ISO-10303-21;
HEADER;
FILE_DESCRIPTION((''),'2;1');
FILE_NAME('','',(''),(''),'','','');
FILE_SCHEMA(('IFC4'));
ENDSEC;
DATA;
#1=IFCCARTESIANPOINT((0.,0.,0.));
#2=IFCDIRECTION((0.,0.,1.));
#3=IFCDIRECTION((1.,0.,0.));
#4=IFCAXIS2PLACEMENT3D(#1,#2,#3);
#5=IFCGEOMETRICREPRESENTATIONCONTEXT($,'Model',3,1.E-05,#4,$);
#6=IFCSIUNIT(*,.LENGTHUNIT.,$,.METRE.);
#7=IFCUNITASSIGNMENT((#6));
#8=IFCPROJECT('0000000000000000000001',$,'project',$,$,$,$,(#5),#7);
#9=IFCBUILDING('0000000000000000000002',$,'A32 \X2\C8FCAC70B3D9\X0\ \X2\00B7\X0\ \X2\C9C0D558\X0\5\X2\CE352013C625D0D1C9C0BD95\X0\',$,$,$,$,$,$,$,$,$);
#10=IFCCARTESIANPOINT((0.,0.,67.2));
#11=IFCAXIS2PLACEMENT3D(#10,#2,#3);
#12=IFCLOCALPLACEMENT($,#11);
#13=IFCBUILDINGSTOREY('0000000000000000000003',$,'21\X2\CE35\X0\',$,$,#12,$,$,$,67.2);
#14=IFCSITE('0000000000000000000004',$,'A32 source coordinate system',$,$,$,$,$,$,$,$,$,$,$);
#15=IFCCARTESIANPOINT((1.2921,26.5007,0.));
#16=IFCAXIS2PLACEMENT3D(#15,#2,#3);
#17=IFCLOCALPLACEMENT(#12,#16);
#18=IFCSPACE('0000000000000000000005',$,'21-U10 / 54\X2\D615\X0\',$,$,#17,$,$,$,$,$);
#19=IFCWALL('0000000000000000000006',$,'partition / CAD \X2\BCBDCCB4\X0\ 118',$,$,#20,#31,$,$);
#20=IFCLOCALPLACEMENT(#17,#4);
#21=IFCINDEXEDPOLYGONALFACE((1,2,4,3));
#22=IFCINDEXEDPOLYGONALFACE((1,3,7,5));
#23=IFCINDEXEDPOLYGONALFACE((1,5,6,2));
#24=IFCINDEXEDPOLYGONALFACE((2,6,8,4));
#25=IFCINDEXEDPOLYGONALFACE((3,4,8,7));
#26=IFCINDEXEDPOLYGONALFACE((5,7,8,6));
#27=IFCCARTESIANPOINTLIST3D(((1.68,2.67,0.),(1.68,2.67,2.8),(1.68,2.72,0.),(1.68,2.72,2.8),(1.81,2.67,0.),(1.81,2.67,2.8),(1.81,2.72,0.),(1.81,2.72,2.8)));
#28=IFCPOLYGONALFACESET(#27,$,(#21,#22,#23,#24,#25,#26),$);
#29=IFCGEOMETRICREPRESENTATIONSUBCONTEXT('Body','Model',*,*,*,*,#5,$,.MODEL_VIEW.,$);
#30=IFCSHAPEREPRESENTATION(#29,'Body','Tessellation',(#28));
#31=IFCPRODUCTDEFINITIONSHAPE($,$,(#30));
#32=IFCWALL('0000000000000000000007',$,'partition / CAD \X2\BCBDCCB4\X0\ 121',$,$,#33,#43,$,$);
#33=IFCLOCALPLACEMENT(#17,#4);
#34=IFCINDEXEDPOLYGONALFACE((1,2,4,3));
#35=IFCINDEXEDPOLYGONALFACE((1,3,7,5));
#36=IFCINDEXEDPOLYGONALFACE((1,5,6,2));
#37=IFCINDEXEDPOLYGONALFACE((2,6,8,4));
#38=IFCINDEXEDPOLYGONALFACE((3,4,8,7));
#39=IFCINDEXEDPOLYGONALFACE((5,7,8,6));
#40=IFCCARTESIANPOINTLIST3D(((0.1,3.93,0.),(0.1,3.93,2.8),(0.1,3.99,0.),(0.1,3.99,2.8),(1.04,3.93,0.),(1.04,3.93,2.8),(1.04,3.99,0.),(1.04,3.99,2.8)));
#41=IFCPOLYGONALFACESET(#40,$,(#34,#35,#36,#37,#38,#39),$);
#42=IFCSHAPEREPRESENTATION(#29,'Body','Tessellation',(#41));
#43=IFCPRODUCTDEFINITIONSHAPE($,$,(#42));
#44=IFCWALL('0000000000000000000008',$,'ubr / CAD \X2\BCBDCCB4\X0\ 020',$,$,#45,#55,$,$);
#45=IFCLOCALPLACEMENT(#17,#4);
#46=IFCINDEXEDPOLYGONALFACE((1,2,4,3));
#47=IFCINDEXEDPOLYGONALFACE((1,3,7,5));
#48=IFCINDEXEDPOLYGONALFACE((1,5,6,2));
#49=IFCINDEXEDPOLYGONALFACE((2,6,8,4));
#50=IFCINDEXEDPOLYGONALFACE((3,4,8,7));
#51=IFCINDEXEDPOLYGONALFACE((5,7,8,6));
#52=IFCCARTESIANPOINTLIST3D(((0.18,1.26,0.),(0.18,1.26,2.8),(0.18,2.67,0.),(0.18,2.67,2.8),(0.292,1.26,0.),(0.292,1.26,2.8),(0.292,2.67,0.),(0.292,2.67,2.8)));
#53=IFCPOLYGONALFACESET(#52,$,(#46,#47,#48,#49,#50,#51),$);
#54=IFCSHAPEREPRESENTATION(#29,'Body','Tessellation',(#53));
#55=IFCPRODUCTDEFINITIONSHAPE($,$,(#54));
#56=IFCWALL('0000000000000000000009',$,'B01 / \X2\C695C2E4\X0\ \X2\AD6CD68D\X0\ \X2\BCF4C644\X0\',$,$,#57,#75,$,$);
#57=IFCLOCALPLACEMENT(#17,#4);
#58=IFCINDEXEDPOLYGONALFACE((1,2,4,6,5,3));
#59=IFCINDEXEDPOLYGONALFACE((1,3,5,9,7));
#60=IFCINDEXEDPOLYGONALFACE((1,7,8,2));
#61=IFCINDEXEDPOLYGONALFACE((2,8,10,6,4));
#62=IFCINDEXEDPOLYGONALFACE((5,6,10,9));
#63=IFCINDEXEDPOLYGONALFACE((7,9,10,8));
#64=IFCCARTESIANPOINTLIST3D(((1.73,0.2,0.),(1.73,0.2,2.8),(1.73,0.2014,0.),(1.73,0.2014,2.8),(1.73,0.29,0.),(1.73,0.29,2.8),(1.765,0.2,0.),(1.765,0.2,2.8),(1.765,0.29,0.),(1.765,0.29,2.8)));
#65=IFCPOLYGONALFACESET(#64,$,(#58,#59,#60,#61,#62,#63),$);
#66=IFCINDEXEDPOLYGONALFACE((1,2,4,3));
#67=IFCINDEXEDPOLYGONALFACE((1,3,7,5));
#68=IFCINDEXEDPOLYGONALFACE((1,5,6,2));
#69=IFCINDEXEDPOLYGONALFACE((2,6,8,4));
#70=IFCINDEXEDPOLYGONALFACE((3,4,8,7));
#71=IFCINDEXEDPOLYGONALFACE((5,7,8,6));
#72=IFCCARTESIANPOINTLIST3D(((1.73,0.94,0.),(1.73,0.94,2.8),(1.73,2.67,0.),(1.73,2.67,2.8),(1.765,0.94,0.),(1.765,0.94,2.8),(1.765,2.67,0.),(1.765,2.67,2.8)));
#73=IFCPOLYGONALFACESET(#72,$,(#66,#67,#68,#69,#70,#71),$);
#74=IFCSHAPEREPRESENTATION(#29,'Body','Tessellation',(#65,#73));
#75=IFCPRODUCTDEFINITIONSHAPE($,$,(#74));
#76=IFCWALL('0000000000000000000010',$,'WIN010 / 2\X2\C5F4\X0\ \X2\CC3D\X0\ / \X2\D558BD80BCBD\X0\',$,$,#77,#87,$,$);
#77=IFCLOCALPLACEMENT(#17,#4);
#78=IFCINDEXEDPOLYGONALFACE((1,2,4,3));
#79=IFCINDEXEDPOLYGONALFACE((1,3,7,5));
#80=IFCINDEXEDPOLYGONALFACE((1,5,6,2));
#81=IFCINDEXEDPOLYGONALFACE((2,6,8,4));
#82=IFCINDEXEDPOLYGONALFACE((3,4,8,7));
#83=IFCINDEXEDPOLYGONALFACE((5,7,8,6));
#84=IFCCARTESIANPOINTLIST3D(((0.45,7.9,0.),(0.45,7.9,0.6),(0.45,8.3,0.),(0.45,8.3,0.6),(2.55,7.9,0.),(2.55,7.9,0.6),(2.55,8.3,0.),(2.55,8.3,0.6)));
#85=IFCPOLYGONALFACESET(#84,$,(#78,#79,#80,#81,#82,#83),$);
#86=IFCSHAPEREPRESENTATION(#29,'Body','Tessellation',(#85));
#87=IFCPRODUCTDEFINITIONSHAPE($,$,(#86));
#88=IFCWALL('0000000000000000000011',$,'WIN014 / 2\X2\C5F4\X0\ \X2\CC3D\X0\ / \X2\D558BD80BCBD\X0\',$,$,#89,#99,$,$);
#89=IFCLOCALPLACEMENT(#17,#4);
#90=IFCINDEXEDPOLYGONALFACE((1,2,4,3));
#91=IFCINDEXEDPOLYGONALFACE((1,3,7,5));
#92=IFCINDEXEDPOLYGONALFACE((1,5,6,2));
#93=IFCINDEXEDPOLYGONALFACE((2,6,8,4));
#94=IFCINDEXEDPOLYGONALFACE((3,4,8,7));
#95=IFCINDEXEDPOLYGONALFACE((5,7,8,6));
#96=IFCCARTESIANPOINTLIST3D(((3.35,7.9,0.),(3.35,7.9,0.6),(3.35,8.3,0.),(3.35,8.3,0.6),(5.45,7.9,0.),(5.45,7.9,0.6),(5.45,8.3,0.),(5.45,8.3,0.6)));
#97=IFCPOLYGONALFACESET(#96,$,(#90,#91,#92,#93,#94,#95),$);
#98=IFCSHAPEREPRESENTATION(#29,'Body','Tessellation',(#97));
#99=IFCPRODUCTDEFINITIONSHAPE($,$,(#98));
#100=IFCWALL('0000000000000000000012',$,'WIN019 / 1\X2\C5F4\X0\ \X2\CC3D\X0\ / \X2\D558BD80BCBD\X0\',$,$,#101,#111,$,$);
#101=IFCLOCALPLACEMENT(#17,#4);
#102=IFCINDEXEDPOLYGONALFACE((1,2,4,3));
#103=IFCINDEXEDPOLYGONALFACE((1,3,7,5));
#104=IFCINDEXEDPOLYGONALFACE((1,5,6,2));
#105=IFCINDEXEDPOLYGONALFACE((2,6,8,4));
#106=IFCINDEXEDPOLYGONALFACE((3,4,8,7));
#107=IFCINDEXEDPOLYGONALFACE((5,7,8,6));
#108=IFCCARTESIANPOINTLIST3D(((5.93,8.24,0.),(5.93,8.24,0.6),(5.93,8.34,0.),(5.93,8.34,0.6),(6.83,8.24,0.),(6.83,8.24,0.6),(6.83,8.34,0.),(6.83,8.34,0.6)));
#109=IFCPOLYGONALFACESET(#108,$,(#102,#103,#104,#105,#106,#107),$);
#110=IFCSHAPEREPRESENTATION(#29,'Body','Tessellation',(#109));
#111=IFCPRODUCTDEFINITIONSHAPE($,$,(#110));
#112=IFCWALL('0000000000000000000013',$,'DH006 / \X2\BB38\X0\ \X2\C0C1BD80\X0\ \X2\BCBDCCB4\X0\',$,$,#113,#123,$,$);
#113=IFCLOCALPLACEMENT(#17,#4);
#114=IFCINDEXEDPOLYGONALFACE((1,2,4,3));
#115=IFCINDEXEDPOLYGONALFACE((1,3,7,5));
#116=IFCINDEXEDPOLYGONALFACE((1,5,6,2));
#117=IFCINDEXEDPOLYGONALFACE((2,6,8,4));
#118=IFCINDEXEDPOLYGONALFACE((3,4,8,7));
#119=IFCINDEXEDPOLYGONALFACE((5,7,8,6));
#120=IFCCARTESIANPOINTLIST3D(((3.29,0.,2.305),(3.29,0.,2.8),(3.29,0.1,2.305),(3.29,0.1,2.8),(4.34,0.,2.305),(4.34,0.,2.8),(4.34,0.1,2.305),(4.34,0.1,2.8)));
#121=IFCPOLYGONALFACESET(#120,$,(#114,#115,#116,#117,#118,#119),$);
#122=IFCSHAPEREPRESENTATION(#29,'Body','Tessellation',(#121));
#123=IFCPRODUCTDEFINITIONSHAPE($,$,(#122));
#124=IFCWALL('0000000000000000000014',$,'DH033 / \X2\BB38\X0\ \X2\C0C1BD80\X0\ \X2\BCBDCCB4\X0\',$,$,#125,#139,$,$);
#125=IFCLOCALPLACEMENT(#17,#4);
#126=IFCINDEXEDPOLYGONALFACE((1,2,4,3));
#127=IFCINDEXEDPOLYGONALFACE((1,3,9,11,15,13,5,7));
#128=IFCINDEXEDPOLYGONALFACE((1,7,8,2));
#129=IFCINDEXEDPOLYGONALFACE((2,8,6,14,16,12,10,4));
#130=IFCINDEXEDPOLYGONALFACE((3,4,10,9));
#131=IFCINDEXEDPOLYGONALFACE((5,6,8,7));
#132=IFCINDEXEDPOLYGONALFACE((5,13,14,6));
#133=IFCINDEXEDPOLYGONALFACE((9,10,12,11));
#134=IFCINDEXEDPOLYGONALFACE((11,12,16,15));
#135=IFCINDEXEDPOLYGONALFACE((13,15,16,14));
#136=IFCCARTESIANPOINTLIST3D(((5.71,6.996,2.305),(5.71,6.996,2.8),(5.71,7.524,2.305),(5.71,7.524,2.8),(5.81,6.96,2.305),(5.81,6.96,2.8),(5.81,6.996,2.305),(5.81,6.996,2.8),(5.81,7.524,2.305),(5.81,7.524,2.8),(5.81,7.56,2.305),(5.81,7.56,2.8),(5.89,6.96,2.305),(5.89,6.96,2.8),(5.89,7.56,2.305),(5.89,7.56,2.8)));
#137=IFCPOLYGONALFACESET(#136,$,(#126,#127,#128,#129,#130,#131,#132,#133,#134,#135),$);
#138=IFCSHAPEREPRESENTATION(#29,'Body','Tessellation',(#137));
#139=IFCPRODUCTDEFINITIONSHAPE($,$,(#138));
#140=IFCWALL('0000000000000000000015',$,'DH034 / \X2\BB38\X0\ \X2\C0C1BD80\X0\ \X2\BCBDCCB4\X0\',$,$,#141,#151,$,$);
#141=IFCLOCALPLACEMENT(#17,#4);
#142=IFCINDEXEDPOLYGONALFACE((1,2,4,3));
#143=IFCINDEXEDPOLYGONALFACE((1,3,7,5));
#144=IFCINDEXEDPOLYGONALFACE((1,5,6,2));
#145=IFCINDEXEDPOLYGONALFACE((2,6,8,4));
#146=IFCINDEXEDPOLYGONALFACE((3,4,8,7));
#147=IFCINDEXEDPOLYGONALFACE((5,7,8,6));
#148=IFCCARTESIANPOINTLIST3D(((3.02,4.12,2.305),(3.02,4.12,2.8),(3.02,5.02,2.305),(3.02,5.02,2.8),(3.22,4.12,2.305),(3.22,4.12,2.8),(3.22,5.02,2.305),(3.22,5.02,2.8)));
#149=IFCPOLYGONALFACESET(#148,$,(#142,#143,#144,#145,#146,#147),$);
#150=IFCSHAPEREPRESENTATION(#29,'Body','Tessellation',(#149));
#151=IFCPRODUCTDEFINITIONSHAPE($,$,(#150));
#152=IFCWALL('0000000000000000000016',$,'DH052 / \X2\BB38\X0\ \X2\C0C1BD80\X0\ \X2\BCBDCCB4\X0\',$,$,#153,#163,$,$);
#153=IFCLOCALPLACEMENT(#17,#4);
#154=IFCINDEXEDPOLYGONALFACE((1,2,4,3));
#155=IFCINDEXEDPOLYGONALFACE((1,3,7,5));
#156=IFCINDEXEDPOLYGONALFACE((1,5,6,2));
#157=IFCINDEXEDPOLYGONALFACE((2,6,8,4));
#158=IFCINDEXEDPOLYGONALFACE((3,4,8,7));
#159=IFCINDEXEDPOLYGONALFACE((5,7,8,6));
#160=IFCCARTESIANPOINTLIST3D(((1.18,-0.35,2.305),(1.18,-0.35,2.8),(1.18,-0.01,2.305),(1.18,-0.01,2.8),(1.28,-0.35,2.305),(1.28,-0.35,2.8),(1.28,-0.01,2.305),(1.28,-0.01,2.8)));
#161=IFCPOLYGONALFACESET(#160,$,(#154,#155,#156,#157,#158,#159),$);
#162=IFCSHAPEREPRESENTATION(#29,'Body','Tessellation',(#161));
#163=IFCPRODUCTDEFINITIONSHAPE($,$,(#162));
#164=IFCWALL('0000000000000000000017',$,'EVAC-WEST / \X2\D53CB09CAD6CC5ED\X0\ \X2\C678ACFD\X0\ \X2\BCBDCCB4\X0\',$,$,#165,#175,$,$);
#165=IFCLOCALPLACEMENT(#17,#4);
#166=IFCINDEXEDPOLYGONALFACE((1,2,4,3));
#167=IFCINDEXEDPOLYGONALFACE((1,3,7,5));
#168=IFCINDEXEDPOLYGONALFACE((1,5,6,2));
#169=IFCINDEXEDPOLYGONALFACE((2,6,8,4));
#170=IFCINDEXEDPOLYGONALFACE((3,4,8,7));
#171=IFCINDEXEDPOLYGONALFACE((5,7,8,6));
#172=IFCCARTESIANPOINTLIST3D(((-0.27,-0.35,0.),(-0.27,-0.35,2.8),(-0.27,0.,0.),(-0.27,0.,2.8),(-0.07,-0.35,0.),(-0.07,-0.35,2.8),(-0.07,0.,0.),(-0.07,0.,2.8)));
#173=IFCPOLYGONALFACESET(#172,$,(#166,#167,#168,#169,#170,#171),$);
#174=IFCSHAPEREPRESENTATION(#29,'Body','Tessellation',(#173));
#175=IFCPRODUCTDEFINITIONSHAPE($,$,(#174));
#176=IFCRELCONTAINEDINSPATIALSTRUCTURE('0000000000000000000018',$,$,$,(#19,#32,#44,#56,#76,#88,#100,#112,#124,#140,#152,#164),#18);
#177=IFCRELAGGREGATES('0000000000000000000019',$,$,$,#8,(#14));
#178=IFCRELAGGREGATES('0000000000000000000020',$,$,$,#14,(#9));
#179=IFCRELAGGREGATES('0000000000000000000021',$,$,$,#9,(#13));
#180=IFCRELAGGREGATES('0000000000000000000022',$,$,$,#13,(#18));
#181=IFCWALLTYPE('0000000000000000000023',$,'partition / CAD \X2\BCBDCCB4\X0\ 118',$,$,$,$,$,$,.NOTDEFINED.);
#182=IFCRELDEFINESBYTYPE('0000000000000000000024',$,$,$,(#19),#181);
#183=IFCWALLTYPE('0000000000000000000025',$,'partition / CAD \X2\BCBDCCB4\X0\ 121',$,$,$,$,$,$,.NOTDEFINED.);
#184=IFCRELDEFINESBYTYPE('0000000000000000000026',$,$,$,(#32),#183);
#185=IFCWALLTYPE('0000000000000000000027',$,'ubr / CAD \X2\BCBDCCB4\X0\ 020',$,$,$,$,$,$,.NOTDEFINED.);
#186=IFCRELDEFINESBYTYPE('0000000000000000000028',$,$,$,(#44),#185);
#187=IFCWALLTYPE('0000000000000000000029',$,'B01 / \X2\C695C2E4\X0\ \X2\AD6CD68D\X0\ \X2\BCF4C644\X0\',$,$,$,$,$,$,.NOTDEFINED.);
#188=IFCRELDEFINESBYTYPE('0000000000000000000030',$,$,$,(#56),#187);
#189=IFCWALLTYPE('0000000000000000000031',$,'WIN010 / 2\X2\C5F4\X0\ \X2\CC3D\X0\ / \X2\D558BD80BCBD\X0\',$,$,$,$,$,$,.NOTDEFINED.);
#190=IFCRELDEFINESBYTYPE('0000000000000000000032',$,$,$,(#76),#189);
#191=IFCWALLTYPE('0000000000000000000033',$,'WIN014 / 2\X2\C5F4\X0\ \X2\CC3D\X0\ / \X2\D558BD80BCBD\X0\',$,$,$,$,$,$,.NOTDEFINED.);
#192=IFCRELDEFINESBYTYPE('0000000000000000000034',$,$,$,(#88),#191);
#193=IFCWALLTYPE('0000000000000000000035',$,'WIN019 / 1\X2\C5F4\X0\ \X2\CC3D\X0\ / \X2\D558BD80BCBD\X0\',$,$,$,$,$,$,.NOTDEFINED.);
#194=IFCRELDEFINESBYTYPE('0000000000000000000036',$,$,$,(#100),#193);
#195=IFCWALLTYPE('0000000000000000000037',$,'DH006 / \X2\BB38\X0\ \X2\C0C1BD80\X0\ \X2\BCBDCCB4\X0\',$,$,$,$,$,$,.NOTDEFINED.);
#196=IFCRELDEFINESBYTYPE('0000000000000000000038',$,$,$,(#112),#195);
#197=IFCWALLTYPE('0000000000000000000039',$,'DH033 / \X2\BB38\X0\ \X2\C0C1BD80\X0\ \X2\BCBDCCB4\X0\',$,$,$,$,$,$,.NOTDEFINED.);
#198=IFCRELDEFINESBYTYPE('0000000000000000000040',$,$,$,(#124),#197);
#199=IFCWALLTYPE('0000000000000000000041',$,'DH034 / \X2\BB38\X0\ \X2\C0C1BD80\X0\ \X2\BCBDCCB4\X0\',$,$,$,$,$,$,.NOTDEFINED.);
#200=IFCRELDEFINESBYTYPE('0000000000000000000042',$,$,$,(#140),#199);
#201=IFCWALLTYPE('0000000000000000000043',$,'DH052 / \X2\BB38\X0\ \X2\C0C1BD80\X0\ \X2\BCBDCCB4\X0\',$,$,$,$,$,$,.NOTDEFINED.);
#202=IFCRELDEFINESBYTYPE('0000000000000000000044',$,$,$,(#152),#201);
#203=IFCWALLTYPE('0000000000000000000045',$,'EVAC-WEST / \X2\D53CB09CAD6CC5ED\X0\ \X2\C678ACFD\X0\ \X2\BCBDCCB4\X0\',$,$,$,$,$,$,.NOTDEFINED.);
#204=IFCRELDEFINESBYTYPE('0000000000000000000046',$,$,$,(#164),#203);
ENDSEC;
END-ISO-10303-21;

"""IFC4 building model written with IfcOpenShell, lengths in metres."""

from ifc_helpers import new_model, si_unit, frame, origin, origin_with_axes, place, context, subcontext, project, spatial, polyline, outline, extrude, source, transform, mapped, type_object, type_shapes, element, save


model = new_model("IFC4")

# Units and contexts
model_context = context("Model", 3, precision=1e-05, world=origin_with_axes())
body_context = subcontext(model_context, "Body", "Model", "MODEL_VIEW")
ifc_project = project(units=[si_unit("LENGTHUNIT", "METRE")], contexts=[model_context])

# Site, building, storey, space
site = spatial("IfcSite", under=ifc_project, Name="A32 source coordinate system")
building = spatial("IfcBuilding", under=site, Name="A32 주거동 · 지하5층–옥탑지붕")
storey_placement = place(None, frame((0.0, 0.0, 67.2), z_axis=(0.0, 0.0, 1.0), x_axis=(1.0, 0.0, 0.0)))
storey = spatial("IfcBuildingStorey", under=building, at=storey_placement, Name="21층", Elevation=67.2)
space_placement = place(storey_placement, frame((1.2921, 26.5007, 0.0), z_axis=(0.0, 0.0, 1.0), x_axis=(1.0, 0.0, 0.0)))
space = spatial("IfcSpace", under=storey, at=space_placement, Name="21-U10 / 54형")

# Walls
wall_type_1 = type_object("IfcWallType", Name="partition / CAD 벽체 118", PredefinedType="NOTDEFINED")
shared_shape_1 = source(origin(), body_context, "Body", "SweptSolid", [
    extrude(outline(polyline([(1.81, 2.67), (1.68, 2.67), (1.68, 2.72), (1.81, 2.72), (1.81, 2.67)])), origin(), (0.0, 0.0, 1.0), 2.8),
])
type_shapes(wall_type_1, [shared_shape_1])
wall_1_placement = place(space_placement, origin_with_axes())
element("IfcWall", 1, at=wall_1_placement, inside=space, type_object=wall_type_1, Name="partition / CAD 벽체 118", context=body_context, shape_type="MappedRepresentation", body=[
    mapped(shared_shape_1, transform((0.0, 0.0, 0.0), scale=1.0)),
])
wall_type_2 = type_object("IfcWallType", Name="partition / CAD 벽체 121", PredefinedType="NOTDEFINED")
shared_shape_2 = source(origin(), body_context, "Body", "SweptSolid", [
    extrude(outline(polyline([(0.1, 3.99), (1.04, 3.99), (1.04, 3.93), (0.1, 3.93), (0.1, 3.99)])), origin(), (0.0, 0.0, 1.0), 2.8),
])
type_shapes(wall_type_2, [shared_shape_2])
wall_2_placement = place(space_placement, origin_with_axes())
element("IfcWall", 2, at=wall_2_placement, inside=space, type_object=wall_type_2, Name="partition / CAD 벽체 121", context=body_context, shape_type="MappedRepresentation", body=[
    mapped(shared_shape_2, transform((0.0, 0.0, 0.0), scale=1.0)),
])
wall_type_3 = type_object("IfcWallType", Name="ubr / CAD 벽체 020", PredefinedType="NOTDEFINED")
shared_shape_3 = source(origin(), body_context, "Body", "SweptSolid", [
    extrude(outline(polyline([(0.18, 1.26), (0.18, 2.67), (0.292, 2.67), (0.292, 1.26), (0.18, 1.26)])), origin(), (0.0, 0.0, 1.0), 2.8),
])
type_shapes(wall_type_3, [shared_shape_3])
wall_3_placement = place(space_placement, origin_with_axes())
element("IfcWall", 3, at=wall_3_placement, inside=space, type_object=wall_type_3, Name="ubr / CAD 벽체 020", context=body_context, shape_type="MappedRepresentation", body=[
    mapped(shared_shape_3, transform((0.0, 0.0, 0.0), scale=1.0)),
])
wall_type_4 = type_object("IfcWallType", Name="B01 / 욕실 구획 보완", PredefinedType="NOTDEFINED")
shared_shape_4 = source(origin(), body_context, "Body", "SweptSolid", [
    extrude(outline(polyline([(1.765, 0.2), (1.73, 0.2), (1.73, 0.2014), (1.73, 0.29), (1.765, 0.29), (1.765, 0.2)])), origin(), (0.0, 0.0, 1.0), 2.8),
    extrude(outline(polyline([(1.765, 2.67), (1.765, 0.94), (1.73, 0.94), (1.73, 2.67), (1.765, 2.67)])), origin(), (0.0, 0.0, 1.0), 2.8),
])
type_shapes(wall_type_4, [shared_shape_4])
wall_4_placement = place(space_placement, origin_with_axes())
element("IfcWall", 4, at=wall_4_placement, inside=space, type_object=wall_type_4, Name="B01 / 욕실 구획 보완", context=body_context, shape_type="MappedRepresentation", body=[
    mapped(shared_shape_4, transform((0.0, 0.0, 0.0), scale=1.0)),
])
wall_type_5 = type_object("IfcWallType", Name="WIN010 / 2열 창 / 하부벽", PredefinedType="NOTDEFINED")
shared_shape_5 = source(origin(), body_context, "Body", "SweptSolid", [
    extrude(outline(polyline([(2.55, 8.3), (2.55, 7.9), (0.45, 7.9), (0.45, 8.3), (2.55, 8.3)])), origin(), (0.0, 0.0, 1.0), 0.6),
])
type_shapes(wall_type_5, [shared_shape_5])
wall_5_placement = place(space_placement, origin_with_axes())
element("IfcWall", 5, at=wall_5_placement, inside=space, type_object=wall_type_5, Name="WIN010 / 2열 창 / 하부벽", context=body_context, shape_type="MappedRepresentation", body=[
    mapped(shared_shape_5, transform((0.0, 0.0, 0.0), scale=1.0)),
])
wall_type_6 = type_object("IfcWallType", Name="WIN014 / 2열 창 / 하부벽", PredefinedType="NOTDEFINED")
shared_shape_6 = source(origin(), body_context, "Body", "SweptSolid", [
    extrude(outline(polyline([(5.45, 8.3), (5.45, 7.9), (3.35, 7.9), (3.35, 8.3), (5.45, 8.3)])), origin(), (0.0, 0.0, 1.0), 0.6),
])
type_shapes(wall_type_6, [shared_shape_6])
wall_6_placement = place(space_placement, origin_with_axes())
element("IfcWall", 6, at=wall_6_placement, inside=space, type_object=wall_type_6, Name="WIN014 / 2열 창 / 하부벽", context=body_context, shape_type="MappedRepresentation", body=[
    mapped(shared_shape_6, transform((0.0, 0.0, 0.0), scale=1.0)),
])
wall_type_7 = type_object("IfcWallType", Name="WIN019 / 1열 창 / 하부벽", PredefinedType="NOTDEFINED")
shared_shape_7 = source(origin(), body_context, "Body", "SweptSolid", [
    extrude(outline(polyline([(6.83, 8.34), (6.83, 8.24), (5.93, 8.24), (5.93, 8.34), (6.83, 8.34)])), origin(), (0.0, 0.0, 1.0), 0.6),
])
type_shapes(wall_type_7, [shared_shape_7])
wall_7_placement = place(space_placement, origin_with_axes())
element("IfcWall", 7, at=wall_7_placement, inside=space, type_object=wall_type_7, Name="WIN019 / 1열 창 / 하부벽", context=body_context, shape_type="MappedRepresentation", body=[
    mapped(shared_shape_7, transform((0.0, 0.0, 0.0), scale=1.0)),
])
wall_type_8 = type_object("IfcWallType", Name="DH006 / 문 상부 벽체", PredefinedType="NOTDEFINED")
shared_shape_8 = source(origin(), body_context, "Body", "SweptSolid", [
    extrude(outline(polyline([(4.34, 0.0), (3.29, 0.0), (3.29, 0.1), (4.34, 0.1), (4.34, 0.0)])), frame((0.0, 0.0, 2.305)), (0.0, 0.0, 1.0), 0.495),
])
type_shapes(wall_type_8, [shared_shape_8])
wall_8_placement = place(space_placement, origin_with_axes())
element("IfcWall", 8, at=wall_8_placement, inside=space, type_object=wall_type_8, Name="DH006 / 문 상부 벽체", context=body_context, shape_type="MappedRepresentation", body=[
    mapped(shared_shape_8, transform((0.0, 0.0, 0.0), scale=1.0)),
])
wall_type_9 = type_object("IfcWallType", Name="DH033 / 문 상부 벽체", PredefinedType="NOTDEFINED")
shared_shape_9 = source(origin(), body_context, "Body", "SweptSolid", [
    extrude(outline(polyline([(5.81, 6.996), (5.71, 6.996), (5.71, 7.524), (5.81, 7.524), (5.81, 7.56), (5.89, 7.56), (5.89, 6.96), (5.81, 6.96), (5.81, 6.996)])), frame((0.0, 0.0, 2.305)), (0.0, 0.0, 1.0), 0.495),
])
type_shapes(wall_type_9, [shared_shape_9])
wall_9_placement = place(space_placement, origin_with_axes())
element("IfcWall", 9, at=wall_9_placement, inside=space, type_object=wall_type_9, Name="DH033 / 문 상부 벽체", context=body_context, shape_type="MappedRepresentation", body=[
    mapped(shared_shape_9, transform((0.0, 0.0, 0.0), scale=1.0)),
])
wall_type_10 = type_object("IfcWallType", Name="DH034 / 문 상부 벽체", PredefinedType="NOTDEFINED")
shared_shape_10 = source(origin(), body_context, "Body", "SweptSolid", [
    extrude(outline(polyline([(3.22, 4.12), (3.02, 4.12), (3.02, 5.02), (3.22, 5.02), (3.22, 4.12)])), frame((0.0, 0.0, 2.305)), (0.0, 0.0, 1.0), 0.495),
])
type_shapes(wall_type_10, [shared_shape_10])
wall_10_placement = place(space_placement, origin_with_axes())
element("IfcWall", 10, at=wall_10_placement, inside=space, type_object=wall_type_10, Name="DH034 / 문 상부 벽체", context=body_context, shape_type="MappedRepresentation", body=[
    mapped(shared_shape_10, transform((0.0, 0.0, 0.0), scale=1.0)),
])
wall_type_11 = type_object("IfcWallType", Name="DH052 / 문 상부 벽체", PredefinedType="NOTDEFINED")
shared_shape_11 = source(origin(), body_context, "Body", "SweptSolid", [
    extrude(outline(polyline([(1.28, -0.35), (1.18, -0.35), (1.18, -0.01), (1.28, -0.01), (1.28, -0.35)])), frame((0.0, 0.0, 2.305)), (0.0, 0.0, 1.0), 0.495),
])
type_shapes(wall_type_11, [shared_shape_11])
wall_11_placement = place(space_placement, origin_with_axes())
element("IfcWall", 11, at=wall_11_placement, inside=space, type_object=wall_type_11, Name="DH052 / 문 상부 벽체", context=body_context, shape_type="MappedRepresentation", body=[
    mapped(shared_shape_11, transform((0.0, 0.0, 0.0), scale=1.0)),
])
wall_type_12 = type_object("IfcWallType", Name="EVAC-WEST / 피난구역 외곽 벽체", PredefinedType="NOTDEFINED")
shared_shape_12 = source(origin(), body_context, "Body", "SweptSolid", [
    extrude(outline(polyline([(-0.07, 0.0), (-0.07, -0.35), (-0.27, -0.35), (-0.27, 0.0), (-0.07, 0.0)])), origin(), (0.0, 0.0, 1.0), 2.8),
])
type_shapes(wall_type_12, [shared_shape_12])
wall_12_placement = place(space_placement, origin_with_axes())
element("IfcWall", 12, at=wall_12_placement, inside=space, type_object=wall_type_12, Name="EVAC-WEST / 피난구역 외곽 벽체", context=body_context, shape_type="MappedRepresentation", body=[
    mapped(shared_shape_12, transform((0.0, 0.0, 0.0), scale=1.0)),
])

save(model, "model.ifc")
